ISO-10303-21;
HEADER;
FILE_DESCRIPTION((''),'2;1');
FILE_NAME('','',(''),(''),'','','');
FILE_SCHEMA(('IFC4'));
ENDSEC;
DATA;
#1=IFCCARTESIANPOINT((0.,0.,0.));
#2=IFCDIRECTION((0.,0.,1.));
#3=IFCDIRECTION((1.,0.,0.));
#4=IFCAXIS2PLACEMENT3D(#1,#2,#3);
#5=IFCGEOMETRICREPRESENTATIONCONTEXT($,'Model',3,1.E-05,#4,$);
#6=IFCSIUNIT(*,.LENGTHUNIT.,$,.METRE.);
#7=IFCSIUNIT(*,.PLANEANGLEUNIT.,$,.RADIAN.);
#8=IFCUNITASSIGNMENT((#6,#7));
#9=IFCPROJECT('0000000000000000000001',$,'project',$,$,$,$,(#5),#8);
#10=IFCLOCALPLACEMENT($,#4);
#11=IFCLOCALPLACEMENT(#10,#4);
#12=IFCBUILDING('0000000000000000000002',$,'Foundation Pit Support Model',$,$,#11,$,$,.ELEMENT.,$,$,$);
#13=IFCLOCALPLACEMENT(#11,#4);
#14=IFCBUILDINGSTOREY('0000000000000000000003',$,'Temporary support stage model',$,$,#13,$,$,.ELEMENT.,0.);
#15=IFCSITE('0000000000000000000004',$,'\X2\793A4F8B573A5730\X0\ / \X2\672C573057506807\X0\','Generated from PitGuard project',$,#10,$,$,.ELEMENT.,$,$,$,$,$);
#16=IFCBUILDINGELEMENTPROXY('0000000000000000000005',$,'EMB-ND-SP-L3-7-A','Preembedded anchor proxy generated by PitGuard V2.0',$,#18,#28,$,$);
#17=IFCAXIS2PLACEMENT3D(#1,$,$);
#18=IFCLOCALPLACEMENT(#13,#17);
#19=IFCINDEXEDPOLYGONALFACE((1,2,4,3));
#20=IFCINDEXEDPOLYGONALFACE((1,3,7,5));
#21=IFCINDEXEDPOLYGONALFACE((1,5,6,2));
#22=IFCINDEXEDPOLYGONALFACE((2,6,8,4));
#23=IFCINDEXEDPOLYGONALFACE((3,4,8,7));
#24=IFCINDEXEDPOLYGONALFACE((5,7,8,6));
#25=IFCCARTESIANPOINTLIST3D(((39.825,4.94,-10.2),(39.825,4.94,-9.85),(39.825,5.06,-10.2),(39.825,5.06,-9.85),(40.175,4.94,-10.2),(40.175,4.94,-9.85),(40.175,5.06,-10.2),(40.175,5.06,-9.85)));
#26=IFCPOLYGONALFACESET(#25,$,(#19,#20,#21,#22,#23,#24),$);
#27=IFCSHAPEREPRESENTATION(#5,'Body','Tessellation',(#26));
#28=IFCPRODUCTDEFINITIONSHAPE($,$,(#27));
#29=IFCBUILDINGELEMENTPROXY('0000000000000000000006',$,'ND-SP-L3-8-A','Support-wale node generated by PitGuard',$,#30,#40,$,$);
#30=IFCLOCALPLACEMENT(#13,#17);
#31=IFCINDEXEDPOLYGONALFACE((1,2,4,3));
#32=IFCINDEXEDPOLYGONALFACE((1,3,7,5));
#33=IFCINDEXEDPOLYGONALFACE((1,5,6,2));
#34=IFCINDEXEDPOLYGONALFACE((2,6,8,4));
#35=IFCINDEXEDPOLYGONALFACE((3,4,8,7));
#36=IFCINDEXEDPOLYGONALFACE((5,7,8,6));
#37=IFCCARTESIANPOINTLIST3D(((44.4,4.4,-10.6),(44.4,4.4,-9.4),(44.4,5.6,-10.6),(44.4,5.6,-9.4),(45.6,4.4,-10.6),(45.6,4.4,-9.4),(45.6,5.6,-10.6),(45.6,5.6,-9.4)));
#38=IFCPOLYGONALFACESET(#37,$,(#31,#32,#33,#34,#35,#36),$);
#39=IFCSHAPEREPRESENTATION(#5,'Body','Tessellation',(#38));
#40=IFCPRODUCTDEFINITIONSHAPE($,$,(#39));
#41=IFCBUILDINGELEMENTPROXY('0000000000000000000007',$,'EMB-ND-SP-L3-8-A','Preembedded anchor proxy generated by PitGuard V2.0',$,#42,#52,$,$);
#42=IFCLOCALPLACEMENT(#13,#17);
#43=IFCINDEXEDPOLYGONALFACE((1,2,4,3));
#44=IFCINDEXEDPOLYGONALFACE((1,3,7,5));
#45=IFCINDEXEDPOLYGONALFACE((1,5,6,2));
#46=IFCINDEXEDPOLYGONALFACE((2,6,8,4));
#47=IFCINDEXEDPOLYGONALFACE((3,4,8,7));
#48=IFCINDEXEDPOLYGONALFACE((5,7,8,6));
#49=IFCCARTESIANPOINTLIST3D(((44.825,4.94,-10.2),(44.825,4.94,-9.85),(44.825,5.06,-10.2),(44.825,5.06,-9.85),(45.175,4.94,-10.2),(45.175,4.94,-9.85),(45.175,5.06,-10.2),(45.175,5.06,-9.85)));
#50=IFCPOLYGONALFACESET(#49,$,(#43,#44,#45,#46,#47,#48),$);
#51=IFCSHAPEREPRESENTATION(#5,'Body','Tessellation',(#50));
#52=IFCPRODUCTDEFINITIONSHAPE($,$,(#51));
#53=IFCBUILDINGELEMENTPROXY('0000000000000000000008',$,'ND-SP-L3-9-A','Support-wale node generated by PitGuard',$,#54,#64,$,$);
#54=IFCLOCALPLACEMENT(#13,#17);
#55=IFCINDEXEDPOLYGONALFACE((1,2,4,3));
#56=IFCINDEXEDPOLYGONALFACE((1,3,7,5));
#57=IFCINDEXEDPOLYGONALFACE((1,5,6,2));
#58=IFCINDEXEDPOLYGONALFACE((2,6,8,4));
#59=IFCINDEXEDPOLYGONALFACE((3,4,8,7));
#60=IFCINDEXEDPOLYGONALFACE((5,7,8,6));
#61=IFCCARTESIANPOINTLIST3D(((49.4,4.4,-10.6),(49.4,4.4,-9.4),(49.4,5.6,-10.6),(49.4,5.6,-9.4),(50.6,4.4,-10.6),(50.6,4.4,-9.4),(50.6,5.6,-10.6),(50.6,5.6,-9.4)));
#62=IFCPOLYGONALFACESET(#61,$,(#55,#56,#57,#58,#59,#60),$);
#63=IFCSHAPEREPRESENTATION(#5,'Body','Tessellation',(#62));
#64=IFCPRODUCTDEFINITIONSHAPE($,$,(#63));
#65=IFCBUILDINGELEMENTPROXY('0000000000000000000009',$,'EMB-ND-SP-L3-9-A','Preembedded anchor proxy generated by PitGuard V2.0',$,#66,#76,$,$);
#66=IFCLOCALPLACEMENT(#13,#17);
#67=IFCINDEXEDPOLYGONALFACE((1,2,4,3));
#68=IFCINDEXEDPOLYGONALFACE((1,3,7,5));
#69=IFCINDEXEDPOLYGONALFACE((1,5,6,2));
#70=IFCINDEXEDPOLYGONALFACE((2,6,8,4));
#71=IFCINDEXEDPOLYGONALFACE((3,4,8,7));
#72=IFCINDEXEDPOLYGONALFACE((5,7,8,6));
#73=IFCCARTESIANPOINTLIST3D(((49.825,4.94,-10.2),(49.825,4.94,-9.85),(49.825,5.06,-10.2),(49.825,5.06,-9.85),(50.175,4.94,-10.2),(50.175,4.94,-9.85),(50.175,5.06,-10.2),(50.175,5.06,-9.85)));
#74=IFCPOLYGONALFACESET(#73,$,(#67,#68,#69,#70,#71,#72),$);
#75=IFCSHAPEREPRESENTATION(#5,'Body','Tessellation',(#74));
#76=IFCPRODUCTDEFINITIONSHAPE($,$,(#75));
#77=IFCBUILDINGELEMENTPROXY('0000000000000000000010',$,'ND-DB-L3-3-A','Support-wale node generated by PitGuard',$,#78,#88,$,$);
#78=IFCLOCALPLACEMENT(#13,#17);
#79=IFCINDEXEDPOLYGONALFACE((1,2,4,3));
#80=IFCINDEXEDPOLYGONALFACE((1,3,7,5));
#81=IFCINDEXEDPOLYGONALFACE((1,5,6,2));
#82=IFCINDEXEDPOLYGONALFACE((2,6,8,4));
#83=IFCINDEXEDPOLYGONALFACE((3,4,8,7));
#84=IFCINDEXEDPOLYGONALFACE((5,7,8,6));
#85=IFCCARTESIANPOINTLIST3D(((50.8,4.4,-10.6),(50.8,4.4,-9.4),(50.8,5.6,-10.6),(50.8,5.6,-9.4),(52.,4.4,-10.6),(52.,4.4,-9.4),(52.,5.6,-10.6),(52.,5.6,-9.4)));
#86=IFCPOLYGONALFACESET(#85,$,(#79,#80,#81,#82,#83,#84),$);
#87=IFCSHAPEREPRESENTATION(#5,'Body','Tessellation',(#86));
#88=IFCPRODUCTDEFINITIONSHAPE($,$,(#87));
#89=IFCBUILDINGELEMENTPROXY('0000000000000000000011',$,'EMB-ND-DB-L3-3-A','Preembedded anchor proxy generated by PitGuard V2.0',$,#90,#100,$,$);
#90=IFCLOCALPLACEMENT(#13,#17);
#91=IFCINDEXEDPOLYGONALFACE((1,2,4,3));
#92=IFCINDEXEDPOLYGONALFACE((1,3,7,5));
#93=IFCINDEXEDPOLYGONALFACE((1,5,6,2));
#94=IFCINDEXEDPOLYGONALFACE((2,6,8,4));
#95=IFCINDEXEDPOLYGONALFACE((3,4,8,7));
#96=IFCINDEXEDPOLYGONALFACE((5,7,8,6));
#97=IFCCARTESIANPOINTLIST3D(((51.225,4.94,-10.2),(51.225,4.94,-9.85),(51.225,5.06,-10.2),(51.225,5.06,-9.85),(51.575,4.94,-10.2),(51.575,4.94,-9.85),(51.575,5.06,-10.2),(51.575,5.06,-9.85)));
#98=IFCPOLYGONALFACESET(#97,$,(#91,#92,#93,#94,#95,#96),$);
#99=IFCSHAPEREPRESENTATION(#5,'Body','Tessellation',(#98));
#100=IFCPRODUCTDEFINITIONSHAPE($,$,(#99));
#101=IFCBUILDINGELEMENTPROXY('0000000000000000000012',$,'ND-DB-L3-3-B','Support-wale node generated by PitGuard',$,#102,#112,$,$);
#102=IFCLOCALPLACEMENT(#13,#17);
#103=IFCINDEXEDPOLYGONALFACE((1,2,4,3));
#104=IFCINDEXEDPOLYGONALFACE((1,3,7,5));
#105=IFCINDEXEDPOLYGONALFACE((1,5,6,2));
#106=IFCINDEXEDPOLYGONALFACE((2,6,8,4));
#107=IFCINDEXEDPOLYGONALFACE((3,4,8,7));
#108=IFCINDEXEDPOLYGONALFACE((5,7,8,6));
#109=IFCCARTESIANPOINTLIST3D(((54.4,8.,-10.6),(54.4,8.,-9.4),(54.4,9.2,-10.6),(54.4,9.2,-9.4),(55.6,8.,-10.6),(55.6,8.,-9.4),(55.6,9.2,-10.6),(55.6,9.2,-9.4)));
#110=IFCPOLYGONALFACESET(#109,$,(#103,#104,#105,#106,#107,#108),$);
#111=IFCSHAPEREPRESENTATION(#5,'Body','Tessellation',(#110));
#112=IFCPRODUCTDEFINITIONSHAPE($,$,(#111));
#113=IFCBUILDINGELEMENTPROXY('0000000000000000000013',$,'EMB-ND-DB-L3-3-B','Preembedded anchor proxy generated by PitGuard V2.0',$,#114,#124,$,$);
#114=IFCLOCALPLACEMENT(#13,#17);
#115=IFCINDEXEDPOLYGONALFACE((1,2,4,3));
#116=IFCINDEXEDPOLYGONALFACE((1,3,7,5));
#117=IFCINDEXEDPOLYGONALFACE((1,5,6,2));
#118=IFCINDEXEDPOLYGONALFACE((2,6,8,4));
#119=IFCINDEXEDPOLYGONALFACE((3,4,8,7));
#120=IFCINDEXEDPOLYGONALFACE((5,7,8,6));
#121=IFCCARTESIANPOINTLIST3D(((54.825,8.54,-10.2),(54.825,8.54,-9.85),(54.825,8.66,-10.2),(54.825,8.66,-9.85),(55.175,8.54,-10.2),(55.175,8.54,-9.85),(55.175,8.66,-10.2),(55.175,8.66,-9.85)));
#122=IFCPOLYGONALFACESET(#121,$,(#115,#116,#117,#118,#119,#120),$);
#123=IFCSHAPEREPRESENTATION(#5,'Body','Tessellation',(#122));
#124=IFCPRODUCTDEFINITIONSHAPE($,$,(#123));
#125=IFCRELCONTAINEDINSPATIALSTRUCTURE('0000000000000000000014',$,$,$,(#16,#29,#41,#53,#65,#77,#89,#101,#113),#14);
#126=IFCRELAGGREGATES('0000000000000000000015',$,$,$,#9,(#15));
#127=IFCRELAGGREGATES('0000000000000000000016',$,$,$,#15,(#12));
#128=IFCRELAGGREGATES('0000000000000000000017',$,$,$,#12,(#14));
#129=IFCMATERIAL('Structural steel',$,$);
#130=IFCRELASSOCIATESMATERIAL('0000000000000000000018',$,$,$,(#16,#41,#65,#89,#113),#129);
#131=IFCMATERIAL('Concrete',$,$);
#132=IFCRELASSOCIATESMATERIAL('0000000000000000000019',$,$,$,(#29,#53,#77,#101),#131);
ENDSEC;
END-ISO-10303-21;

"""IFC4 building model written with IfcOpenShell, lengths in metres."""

from ifc_helpers import new_model, si_unit, frame, origin_with_axes, origin_2d, place, context, project, spatial, rectangle, extrude, material, element, save


model = new_model("IFC4")

# Units and contexts
model_context = context("Model", 3, precision=1e-05, world=origin_with_axes())
ifc_project = project(units=[si_unit("LENGTHUNIT", "METRE"), si_unit("PLANEANGLEUNIT", "RADIAN")], contexts=[model_context])

# Site, building, storey
site_placement = place(None, origin_with_axes())
site = spatial("IfcSite", under=ifc_project, at=site_placement, Name="示例场地 / 本地坐标", Description="Generated from PitGuard project", CompositionType="ELEMENT")
building_placement = place(site_placement, origin_with_axes())
building = spatial("IfcBuilding", under=site, at=building_placement, Name="Foundation Pit Support Model", CompositionType="ELEMENT")
storey_placement = place(building_placement, origin_with_axes())
storey = spatial("IfcBuildingStorey", under=building, at=storey_placement, Name="Temporary support stage model", CompositionType="ELEMENT", Elevation=0.0)

# Shared definitions
ifc_material_1 = material(Name="Concrete")

# Shared definitions
ifc_material_2 = material(Name="Structural steel")

# Building element proxies
proxy_1_placement = place(storey_placement, frame((40.0, 5.0, -10.2), z_axis=(0.0, 0.0, 1.0), x_axis=(1.0, 0.0, 0.0)))
element("IfcBuildingElementProxy", 1, at=proxy_1_placement, inside=storey, material=ifc_material_2, Name="EMB-ND-SP-L3-7-A", Description="Preembedded anchor proxy generated by PitGuard V2.0", context=model_context, shape_type="SweptSolid", body=[
    extrude(rectangle(XDim=0.35, YDim=0.12, at=origin_2d()), origin_with_axes(), (0.0, 0.0, 1.0), 0.35),
])
proxy_2_placement = place(storey_placement, frame((45.0, 5.0, -10.6), z_axis=(0.0, 0.0, 1.0), x_axis=(1.0, 0.0, 0.0)))
element("IfcBuildingElementProxy", 2, at=proxy_2_placement, inside=storey, material=ifc_material_1, Name="ND-SP-L3-8-A", Description="Support-wale node generated by PitGuard", context=model_context, shape_type="SweptSolid", body=[
    extrude(rectangle(XDim=1.2, YDim=1.2, at=origin_2d()), origin_with_axes(), (0.0, 0.0, 1.0), 1.2),
])
proxy_3_placement = place(storey_placement, frame((45.0, 5.0, -10.2), z_axis=(0.0, 0.0, 1.0), x_axis=(1.0, 0.0, 0.0)))
element("IfcBuildingElementProxy", 3, at=proxy_3_placement, inside=storey, material=ifc_material_2, Name="EMB-ND-SP-L3-8-A", Description="Preembedded anchor proxy generated by PitGuard V2.0", context=model_context, shape_type="SweptSolid", body=[
    extrude(rectangle(XDim=0.35, YDim=0.12, at=origin_2d()), origin_with_axes(), (0.0, 0.0, 1.0), 0.35),
])
proxy_4_placement = place(storey_placement, frame((50.0, 5.0, -10.6), z_axis=(0.0, 0.0, 1.0), x_axis=(1.0, 0.0, 0.0)))
element("IfcBuildingElementProxy", 4, at=proxy_4_placement, inside=storey, material=ifc_material_1, Name="ND-SP-L3-9-A", Description="Support-wale node generated by PitGuard", context=model_context, shape_type="SweptSolid", body=[
    extrude(rectangle(XDim=1.2, YDim=1.2, at=origin_2d()), origin_with_axes(), (0.0, 0.0, 1.0), 1.2),
])
proxy_5_placement = place(storey_placement, frame((50.0, 5.0, -10.2), z_axis=(0.0, 0.0, 1.0), x_axis=(1.0, 0.0, 0.0)))
element("IfcBuildingElementProxy", 5, at=proxy_5_placement, inside=storey, material=ifc_material_2, Name="EMB-ND-SP-L3-9-A", Description="Preembedded anchor proxy generated by PitGuard V2.0", context=model_context, shape_type="SweptSolid", body=[
    extrude(rectangle(XDim=0.35, YDim=0.12, at=origin_2d()), origin_with_axes(), (0.0, 0.0, 1.0), 0.35),
])
proxy_6_placement = place(storey_placement, frame((51.4, 5.0, -10.6), z_axis=(0.0, 0.0, 1.0), x_axis=(1.0, 0.0, 0.0)))
element("IfcBuildingElementProxy", 6, at=proxy_6_placement, inside=storey, material=ifc_material_1, Name="ND-DB-L3-3-A", Description="Support-wale node generated by PitGuard", context=model_context, shape_type="SweptSolid", body=[
    extrude(rectangle(XDim=1.2, YDim=1.2, at=origin_2d()), origin_with_axes(), (0.0, 0.0, 1.0), 1.2),
])
proxy_7_placement = place(storey_placement, frame((51.4, 5.0, -10.2), z_axis=(0.0, 0.0, 1.0), x_axis=(1.0, 0.0, 0.0)))
element("IfcBuildingElementProxy", 7, at=proxy_7_placement, inside=storey, material=ifc_material_2, Name="EMB-ND-DB-L3-3-A", Description="Preembedded anchor proxy generated by PitGuard V2.0", context=model_context, shape_type="SweptSolid", body=[
    extrude(rectangle(XDim=0.35, YDim=0.12, at=origin_2d()), origin_with_axes(), (0.0, 0.0, 1.0), 0.35),
])
proxy_8_placement = place(storey_placement, frame((55.0, 8.6, -10.6), z_axis=(0.0, 0.0, 1.0), x_axis=(1.0, 0.0, 0.0)))
element("IfcBuildingElementProxy", 8, at=proxy_8_placement, inside=storey, material=ifc_material_1, Name="ND-DB-L3-3-B", Description="Support-wale node generated by PitGuard", context=model_context, shape_type="SweptSolid", body=[
    extrude(rectangle(XDim=1.2, YDim=1.2, at=origin_2d()), origin_with_axes(), (0.0, 0.0, 1.0), 1.2),
])
proxy_9_placement = place(storey_placement, frame((55.0, 8.6, -10.2), z_axis=(0.0, 0.0, 1.0), x_axis=(1.0, 0.0, 0.0)))
element("IfcBuildingElementProxy", 9, at=proxy_9_placement, inside=storey, material=ifc_material_2, Name="EMB-ND-DB-L3-3-B", Description="Preembedded anchor proxy generated by PitGuard V2.0", context=model_context, shape_type="SweptSolid", body=[
    extrude(rectangle(XDim=0.35, YDim=0.12, at=origin_2d()), origin_with_axes(), (0.0, 0.0, 1.0), 0.35),
])

save(model, "model.ifc")
